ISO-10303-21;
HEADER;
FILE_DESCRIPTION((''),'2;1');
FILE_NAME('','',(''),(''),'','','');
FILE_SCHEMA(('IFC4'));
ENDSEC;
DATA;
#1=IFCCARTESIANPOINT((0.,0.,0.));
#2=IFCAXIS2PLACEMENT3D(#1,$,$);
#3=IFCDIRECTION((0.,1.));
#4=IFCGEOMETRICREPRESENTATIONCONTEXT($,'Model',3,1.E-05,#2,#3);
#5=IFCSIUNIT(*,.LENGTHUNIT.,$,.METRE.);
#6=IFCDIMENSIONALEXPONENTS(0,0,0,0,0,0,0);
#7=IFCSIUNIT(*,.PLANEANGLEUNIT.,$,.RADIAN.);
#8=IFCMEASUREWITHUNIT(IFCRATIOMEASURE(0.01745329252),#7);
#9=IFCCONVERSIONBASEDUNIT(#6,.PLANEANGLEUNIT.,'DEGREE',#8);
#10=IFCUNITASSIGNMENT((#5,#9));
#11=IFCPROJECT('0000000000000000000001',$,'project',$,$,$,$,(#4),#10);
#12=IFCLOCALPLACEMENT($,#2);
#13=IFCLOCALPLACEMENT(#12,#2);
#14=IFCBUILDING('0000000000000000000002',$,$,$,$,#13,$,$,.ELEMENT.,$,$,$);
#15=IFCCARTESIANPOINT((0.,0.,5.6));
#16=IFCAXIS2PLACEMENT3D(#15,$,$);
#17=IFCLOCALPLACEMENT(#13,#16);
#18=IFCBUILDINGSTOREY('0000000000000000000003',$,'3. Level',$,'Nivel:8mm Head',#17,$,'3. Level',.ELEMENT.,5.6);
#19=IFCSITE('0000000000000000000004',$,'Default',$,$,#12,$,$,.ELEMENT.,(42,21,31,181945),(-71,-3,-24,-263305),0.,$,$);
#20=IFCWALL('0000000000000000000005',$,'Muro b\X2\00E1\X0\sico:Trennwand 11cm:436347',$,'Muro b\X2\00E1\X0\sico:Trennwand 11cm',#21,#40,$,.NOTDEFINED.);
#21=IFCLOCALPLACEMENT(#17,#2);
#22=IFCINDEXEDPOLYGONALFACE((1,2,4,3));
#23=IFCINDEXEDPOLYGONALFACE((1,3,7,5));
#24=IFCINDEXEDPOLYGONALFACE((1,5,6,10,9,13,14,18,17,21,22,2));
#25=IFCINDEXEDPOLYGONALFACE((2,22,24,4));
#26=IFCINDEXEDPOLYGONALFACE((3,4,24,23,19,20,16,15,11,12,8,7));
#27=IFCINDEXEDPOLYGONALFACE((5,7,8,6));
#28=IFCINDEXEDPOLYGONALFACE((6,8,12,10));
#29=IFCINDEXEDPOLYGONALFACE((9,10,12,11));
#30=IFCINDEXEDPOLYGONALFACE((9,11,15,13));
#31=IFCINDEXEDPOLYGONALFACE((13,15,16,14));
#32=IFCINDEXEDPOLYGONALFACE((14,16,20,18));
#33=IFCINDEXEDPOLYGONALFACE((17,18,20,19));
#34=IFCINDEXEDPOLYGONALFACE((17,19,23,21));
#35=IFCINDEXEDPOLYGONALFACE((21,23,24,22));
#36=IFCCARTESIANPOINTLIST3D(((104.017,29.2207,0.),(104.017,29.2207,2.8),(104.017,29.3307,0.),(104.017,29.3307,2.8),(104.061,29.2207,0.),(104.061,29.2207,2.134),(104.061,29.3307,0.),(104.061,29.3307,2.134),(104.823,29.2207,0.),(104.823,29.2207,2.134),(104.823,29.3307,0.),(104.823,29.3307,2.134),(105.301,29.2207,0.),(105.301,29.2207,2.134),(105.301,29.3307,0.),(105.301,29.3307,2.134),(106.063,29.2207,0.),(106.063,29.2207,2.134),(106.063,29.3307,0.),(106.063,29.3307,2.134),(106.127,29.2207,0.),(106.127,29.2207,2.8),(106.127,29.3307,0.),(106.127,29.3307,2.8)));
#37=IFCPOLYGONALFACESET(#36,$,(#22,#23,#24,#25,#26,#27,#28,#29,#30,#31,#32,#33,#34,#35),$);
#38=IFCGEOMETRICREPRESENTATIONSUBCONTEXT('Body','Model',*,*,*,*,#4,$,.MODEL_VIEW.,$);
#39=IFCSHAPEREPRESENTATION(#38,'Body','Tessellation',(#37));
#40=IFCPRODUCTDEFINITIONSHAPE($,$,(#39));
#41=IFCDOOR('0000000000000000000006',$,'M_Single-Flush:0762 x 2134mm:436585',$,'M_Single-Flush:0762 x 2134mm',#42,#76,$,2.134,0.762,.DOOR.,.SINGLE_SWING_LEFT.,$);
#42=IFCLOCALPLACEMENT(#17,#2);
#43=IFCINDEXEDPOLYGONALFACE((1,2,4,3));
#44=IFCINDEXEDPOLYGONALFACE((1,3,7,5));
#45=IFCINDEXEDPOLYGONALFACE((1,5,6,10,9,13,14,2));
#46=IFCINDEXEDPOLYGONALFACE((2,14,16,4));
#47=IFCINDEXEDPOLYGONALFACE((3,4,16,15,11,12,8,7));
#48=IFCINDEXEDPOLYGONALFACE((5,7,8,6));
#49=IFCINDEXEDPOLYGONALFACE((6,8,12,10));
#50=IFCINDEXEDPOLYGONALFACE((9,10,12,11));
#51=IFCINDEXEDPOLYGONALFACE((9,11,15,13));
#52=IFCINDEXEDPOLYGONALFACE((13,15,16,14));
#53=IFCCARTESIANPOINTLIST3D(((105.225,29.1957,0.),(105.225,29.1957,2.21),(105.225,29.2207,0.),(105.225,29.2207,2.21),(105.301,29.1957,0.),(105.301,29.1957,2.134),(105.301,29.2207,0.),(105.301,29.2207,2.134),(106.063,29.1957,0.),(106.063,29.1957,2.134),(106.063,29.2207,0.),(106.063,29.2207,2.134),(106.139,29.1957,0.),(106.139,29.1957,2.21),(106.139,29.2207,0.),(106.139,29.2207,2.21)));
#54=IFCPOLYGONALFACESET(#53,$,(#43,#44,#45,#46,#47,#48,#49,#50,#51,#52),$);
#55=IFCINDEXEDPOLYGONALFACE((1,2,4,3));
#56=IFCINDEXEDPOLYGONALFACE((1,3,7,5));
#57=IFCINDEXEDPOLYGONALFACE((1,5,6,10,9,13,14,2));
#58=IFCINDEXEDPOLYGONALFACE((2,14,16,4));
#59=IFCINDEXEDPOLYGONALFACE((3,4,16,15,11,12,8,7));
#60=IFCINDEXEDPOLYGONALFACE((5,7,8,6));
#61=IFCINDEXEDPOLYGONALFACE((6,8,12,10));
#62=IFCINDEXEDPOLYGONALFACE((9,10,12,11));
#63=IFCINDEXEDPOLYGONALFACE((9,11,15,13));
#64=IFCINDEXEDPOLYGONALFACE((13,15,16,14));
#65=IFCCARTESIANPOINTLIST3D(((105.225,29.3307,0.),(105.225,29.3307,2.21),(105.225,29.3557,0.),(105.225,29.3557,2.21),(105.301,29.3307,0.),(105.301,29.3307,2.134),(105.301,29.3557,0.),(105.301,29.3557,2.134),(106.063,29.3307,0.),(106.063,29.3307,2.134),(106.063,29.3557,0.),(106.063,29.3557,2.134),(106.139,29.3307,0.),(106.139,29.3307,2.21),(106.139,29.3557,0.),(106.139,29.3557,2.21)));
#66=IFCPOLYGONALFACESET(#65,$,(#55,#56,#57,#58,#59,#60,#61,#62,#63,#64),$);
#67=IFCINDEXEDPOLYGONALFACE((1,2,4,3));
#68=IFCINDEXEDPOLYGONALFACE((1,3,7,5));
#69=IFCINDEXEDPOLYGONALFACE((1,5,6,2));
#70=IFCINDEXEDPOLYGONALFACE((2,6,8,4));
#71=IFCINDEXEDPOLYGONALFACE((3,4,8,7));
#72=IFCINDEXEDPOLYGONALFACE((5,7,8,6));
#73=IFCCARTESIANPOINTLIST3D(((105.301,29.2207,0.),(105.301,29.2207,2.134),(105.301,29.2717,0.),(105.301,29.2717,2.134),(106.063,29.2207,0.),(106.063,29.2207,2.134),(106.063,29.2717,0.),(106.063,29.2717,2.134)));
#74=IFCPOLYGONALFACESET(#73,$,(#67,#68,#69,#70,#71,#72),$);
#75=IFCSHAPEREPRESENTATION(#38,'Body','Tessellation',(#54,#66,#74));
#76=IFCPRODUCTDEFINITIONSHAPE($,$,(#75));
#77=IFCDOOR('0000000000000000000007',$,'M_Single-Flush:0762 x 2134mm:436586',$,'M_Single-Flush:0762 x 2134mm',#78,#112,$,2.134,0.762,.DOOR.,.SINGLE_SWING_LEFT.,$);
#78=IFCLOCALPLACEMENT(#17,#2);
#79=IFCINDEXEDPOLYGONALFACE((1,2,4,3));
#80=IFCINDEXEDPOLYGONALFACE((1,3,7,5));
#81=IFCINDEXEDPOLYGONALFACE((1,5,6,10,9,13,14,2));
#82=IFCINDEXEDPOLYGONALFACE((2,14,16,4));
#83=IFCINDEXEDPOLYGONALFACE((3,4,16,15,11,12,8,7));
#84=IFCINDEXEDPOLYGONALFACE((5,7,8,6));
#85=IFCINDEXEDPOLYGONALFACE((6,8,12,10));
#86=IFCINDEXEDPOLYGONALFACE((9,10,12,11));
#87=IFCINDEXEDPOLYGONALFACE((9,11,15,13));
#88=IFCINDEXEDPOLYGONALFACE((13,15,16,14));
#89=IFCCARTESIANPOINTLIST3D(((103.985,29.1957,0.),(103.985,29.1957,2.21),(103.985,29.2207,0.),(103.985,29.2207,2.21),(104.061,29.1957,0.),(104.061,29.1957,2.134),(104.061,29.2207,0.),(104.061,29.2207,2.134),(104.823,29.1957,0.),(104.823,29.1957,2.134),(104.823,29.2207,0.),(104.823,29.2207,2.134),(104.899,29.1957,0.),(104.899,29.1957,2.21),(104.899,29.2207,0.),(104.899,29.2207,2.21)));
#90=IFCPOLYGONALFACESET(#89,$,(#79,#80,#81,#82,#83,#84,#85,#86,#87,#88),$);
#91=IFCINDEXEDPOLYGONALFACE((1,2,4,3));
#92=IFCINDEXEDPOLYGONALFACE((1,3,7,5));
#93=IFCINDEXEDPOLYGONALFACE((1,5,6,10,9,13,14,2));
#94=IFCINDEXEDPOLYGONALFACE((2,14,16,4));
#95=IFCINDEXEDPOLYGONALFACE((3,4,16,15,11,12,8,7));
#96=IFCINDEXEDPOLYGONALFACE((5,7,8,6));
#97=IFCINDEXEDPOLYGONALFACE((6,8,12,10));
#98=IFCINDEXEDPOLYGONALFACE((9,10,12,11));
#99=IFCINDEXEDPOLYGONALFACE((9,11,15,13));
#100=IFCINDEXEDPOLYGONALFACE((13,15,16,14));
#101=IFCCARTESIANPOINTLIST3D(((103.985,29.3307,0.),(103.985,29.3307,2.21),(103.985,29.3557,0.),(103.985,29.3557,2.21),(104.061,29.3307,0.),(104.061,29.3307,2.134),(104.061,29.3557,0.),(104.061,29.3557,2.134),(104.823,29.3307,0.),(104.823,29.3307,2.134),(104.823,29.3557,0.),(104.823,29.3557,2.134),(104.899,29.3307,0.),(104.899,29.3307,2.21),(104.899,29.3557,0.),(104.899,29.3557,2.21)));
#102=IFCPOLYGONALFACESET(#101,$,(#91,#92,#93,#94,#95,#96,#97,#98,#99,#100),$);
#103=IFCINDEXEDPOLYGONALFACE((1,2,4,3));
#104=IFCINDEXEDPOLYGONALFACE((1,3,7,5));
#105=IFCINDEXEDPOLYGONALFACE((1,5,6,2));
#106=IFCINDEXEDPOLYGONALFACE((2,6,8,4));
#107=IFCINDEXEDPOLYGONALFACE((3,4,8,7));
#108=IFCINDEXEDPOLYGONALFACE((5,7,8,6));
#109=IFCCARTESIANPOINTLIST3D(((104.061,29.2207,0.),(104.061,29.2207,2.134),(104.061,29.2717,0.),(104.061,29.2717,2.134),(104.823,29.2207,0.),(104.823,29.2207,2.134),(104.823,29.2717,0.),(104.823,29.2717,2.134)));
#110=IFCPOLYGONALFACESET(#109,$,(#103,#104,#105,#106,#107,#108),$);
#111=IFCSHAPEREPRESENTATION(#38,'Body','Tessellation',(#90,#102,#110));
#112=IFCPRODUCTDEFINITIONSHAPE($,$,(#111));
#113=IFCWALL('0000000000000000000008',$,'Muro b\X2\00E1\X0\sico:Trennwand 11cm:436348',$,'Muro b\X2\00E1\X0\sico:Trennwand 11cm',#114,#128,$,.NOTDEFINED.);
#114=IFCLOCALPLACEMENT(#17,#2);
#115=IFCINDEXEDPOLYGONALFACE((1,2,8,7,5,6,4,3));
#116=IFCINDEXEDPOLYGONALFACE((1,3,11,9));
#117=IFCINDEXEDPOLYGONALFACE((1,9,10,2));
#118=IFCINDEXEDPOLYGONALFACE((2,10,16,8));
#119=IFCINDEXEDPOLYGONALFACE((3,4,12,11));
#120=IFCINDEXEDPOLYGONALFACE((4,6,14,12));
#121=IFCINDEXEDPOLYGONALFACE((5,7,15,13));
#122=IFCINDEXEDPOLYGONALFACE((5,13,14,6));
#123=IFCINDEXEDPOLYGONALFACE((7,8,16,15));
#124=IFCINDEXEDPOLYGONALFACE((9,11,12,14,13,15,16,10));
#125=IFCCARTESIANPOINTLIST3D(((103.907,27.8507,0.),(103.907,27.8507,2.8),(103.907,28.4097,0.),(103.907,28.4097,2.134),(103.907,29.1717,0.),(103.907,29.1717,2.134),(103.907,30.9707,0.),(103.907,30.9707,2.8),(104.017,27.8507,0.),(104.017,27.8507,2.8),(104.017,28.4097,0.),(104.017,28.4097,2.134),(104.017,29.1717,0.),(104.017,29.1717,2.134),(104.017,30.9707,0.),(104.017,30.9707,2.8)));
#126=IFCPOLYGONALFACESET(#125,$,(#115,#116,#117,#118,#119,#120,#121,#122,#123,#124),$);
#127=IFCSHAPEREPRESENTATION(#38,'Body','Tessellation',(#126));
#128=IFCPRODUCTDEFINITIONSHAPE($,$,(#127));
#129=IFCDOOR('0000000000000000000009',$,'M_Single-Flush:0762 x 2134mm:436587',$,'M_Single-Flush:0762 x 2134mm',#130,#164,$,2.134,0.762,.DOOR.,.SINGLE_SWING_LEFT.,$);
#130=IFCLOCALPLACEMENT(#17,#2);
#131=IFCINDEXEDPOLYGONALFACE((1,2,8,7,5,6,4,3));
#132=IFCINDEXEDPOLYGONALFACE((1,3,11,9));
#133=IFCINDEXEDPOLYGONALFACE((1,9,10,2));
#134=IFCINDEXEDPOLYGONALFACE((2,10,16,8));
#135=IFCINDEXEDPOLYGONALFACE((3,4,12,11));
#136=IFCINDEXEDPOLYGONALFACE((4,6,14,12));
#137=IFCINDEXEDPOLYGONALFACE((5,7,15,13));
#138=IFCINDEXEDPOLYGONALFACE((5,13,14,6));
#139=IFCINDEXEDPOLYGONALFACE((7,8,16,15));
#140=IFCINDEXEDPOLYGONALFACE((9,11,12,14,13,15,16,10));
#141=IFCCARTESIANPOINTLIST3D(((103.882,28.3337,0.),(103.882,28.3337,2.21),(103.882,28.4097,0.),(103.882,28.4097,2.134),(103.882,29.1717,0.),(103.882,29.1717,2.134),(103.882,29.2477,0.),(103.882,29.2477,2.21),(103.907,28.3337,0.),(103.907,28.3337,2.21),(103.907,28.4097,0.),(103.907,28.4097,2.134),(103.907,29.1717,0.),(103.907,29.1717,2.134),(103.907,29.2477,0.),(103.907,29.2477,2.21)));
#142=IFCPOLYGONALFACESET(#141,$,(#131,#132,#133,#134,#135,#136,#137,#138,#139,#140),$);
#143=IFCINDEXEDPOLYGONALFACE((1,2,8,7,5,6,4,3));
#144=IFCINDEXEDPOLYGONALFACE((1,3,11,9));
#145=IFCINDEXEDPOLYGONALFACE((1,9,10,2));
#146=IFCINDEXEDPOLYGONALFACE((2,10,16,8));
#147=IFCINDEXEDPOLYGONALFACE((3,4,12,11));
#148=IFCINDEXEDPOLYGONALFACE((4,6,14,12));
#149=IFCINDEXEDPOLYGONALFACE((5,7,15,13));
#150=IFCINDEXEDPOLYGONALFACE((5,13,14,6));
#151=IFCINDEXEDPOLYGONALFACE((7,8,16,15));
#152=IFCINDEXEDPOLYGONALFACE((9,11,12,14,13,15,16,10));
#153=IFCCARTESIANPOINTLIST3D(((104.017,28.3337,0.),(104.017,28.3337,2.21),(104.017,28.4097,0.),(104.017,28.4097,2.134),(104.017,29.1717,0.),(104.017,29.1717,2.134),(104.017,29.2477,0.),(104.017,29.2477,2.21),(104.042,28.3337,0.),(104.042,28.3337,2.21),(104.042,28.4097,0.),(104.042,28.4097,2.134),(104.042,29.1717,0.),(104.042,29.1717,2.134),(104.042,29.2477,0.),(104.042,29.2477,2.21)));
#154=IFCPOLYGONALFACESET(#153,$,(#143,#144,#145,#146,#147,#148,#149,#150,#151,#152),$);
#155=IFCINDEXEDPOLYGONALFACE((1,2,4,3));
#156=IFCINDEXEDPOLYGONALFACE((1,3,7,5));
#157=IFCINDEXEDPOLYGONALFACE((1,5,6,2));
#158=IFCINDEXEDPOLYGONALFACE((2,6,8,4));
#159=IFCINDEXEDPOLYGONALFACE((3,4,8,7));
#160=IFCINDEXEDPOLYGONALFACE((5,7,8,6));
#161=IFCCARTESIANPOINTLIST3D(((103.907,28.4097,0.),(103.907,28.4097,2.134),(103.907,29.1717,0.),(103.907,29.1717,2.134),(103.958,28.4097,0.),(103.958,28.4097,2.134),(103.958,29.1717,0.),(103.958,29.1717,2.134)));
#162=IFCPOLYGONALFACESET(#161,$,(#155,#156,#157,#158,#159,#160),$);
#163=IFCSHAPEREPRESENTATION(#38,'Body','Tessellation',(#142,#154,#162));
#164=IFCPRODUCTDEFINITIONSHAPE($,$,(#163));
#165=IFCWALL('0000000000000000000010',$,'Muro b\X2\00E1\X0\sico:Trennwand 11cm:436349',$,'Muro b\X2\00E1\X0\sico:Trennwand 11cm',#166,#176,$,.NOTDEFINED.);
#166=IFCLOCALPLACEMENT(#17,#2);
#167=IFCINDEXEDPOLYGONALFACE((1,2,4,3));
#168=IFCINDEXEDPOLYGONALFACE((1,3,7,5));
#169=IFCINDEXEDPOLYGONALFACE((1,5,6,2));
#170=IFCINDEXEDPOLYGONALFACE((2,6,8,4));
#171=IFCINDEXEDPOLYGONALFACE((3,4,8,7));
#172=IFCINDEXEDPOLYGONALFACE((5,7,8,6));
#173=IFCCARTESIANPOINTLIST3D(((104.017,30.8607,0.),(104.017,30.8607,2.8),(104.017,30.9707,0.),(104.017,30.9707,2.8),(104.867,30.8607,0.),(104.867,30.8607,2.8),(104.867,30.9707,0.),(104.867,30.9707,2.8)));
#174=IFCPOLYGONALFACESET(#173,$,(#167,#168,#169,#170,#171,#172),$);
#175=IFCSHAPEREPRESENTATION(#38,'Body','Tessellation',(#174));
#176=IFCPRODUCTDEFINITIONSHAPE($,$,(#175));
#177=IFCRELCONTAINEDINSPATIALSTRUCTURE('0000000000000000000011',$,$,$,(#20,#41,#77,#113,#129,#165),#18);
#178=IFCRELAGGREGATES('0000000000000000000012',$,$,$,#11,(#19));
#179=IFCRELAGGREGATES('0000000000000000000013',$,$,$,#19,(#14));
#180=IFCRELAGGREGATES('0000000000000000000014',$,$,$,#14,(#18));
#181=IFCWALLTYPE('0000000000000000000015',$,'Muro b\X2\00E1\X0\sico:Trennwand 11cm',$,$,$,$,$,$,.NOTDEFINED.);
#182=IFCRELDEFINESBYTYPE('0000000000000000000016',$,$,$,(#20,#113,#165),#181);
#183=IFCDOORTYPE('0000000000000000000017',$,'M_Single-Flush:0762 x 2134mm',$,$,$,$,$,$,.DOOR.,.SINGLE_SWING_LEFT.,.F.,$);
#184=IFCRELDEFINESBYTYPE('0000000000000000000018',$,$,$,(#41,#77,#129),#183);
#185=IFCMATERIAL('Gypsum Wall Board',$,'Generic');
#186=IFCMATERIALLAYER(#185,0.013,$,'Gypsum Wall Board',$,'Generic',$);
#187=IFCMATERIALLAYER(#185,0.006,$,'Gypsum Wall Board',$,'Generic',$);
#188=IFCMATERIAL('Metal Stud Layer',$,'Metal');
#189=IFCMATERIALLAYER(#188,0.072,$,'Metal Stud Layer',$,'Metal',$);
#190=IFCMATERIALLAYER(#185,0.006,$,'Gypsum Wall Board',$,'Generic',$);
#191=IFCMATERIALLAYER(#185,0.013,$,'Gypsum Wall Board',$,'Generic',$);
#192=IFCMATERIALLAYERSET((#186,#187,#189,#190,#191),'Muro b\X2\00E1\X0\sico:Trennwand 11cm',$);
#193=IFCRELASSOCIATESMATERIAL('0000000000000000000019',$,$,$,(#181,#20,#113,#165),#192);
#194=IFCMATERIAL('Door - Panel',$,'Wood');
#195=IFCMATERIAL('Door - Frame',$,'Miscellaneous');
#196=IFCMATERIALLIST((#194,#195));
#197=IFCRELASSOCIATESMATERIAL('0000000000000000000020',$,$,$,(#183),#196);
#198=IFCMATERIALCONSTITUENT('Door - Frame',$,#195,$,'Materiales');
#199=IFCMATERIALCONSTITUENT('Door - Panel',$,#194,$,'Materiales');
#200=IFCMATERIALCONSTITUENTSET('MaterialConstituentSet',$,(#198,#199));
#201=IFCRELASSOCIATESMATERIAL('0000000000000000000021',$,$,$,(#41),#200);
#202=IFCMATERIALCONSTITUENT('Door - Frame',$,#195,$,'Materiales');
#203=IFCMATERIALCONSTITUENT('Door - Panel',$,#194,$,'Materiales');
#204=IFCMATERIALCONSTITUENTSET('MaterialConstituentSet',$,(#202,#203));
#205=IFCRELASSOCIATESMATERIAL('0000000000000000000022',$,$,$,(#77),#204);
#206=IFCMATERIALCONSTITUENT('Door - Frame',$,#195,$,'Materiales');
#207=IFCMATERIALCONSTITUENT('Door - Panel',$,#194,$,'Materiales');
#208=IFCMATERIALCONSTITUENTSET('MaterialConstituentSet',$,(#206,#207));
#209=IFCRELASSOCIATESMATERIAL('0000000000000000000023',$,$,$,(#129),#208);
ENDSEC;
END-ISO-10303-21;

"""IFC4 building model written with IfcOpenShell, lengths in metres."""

from ifc_helpers import new_model, entity, si_unit, converted_unit, direction, frame, frame_2d, origin, origin_2d_with_axis, place, context, subcontext, project, spatial, polyline, rectangle, outline, extrude, source, transform, mapped, material, material_list, layer, layer_set, layer_usage, constituent, constituent_set, type_object, type_shapes, element, fill, save


model = new_model("IFC4")

# Units and contexts
model_context = context("Model", 3, precision=1e-05, world=origin(), true_north=direction((0.0, 1.0)))
body_context = subcontext(model_context, "Body", "Model", "MODEL_VIEW")
ifc_project = project(units=[si_unit("LENGTHUNIT", "METRE"), converted_unit("PLANEANGLEUNIT", "DEGREE", entity("IfcRatioMeasure", 0.01745329252), si_unit("PLANEANGLEUNIT", "RADIAN"), dimensions=[0, 0, 0, 0, 0, 0, 0])], contexts=[model_context])

# Site, building, storey
site_placement = place(None, origin())
site = spatial("IfcSite", under=ifc_project, at=site_placement, Name="Default", CompositionType="ELEMENT", RefLatitude=(42, 21, 31, 181945), RefLongitude=(-71, -3, -24, -263305), RefElevation=0.0)
building_placement = place(site_placement, origin())
building = spatial("IfcBuilding", under=site, at=building_placement, CompositionType="ELEMENT")
storey_placement = place(building_placement, frame((0.0, 0.0, 5.6)))
storey = spatial("IfcBuildingStorey", under=building, at=storey_placement, Name="3. Level", ObjectType="Nivel:8mm Head", LongName="3. Level", CompositionType="ELEMENT", Elevation=5.6)

# Shared definitions
ifc_material_1 = material(Name="Gypsum Wall Board", Category="Generic")
ifc_layer_1 = layer(ifc_material_1, 0.013, Name="Gypsum Wall Board", Category="Generic")
ifc_layer_2 = layer(ifc_material_1, 0.006, Name="Gypsum Wall Board", Category="Generic")
ifc_material_2 = material(Name="Metal Stud Layer", Category="Metal")
ifc_layer_3 = layer(ifc_material_2, 0.072, Name="Metal Stud Layer", Category="Metal")
ifc_layer_4 = layer(ifc_material_1, 0.006, Name="Gypsum Wall Board", Category="Generic")
ifc_layer_5 = layer(ifc_material_1, 0.013, Name="Gypsum Wall Board", Category="Generic")
ifc_layer_set_1 = layer_set([ifc_layer_1, ifc_layer_2, ifc_layer_3, ifc_layer_4, ifc_layer_5], Name="Muro básico:Trennwand 11cm")
wall_type_1 = type_object("IfcWallType", Name="Muro básico:Trennwand 11cm", PredefinedType="NOTDEFINED", material=ifc_layer_set_1)
ifc_material_3 = material(Name="Door - Frame", Category="Miscellaneous")

# Shared definitions
ifc_material_4 = material(Name="Door - Panel", Category="Wood")
ifc_material_list_1 = material_list([ifc_material_4, ifc_material_3])
door_type_1 = type_object("IfcDoorType", Name="M_Single-Flush:0762 x 2134mm", OperationType="SINGLE_SWING_LEFT", ParameterTakesPrecedence=False, PredefinedType="DOOR", material=ifc_material_list_1)
shared_shape_1 = source(origin(), body_context, "Body", "SweptSolid", [
    extrude(outline(polyline([(-0.457, -1.124), (0.457, -1.124), (0.457, 1.086), (0.381, 1.086), (0.381, -1.048), (-0.381, -1.048), (-0.381, 1.086), (-0.457, 1.086), (-0.457, -1.124)])), frame((0.381, 0.135, 1.086), z_axis=(0.0, -1.0, 0.0), x_axis=(-1.0, 0.0, 0.0)), (0.0, 0.0, 1.0), 0.025),
    extrude(outline(polyline([(-1.124, -0.457), (1.086, -0.457), (1.086, -0.381), (-1.048, -0.381), (-1.048, 0.381), (1.086, 0.381), (1.086, 0.457), (-1.124, 0.457), (-1.124, -0.457)])), frame((0.381, 0.0, 1.086), z_axis=(0.0, -1.0, 0.0), x_axis=(0.0, 0.0, -1.0)), (0.0, 0.0, 1.0), 0.025),
    extrude(rectangle(XDim=0.762, YDim=0.051, at=origin_2d_with_axis()), frame((0.381, 0.0845, 0.0)), (0.0, 0.0, 1.0), 2.134),
])
type_shapes(door_type_1, [shared_shape_1])

# Wall, openings, doors
ifc_layer_usage_1 = layer_usage(ifc_layer_set_1, "AXIS2", "NEGATIVE", 0.055)
wall_1_placement = place(storey_placement, frame((106.127, 29.2757, 0.0), z_axis=(0.0, 0.0, 1.0), x_axis=(-1.0, 0.0, 0.0)))
wall_1 = element("IfcWall", 1, at=wall_1_placement, inside=storey, type_object=wall_type_1, material=ifc_layer_usage_1, Name="Muro básico:Trennwand 11cm:436347", ObjectType="Muro básico:Trennwand 11cm", PredefinedType="NOTDEFINED", context=body_context, shape_type="SweptSolid", body=[
    extrude(rectangle(XDim=2.11, YDim=0.11, at=frame_2d((1.055, 0.0), x_axis=(-1.0, 0.0))), origin(), (0.0, 0.0, 1.0), 2.8),
])
opening_1_placement = place(wall_1_placement, frame((0.064, -0.055, 0.0)))
opening_1 = element("IfcOpeningElement", 2, at=opening_1_placement, cuts=wall_1, ObjectType="Opening", PredefinedType="OPENING", context=body_context, shape_type="SweptSolid", body=[
    extrude(rectangle(XDim=0.762, YDim=2.134, at=frame_2d((1.067, 0.381), x_axis=(0.0, -1.0))), frame((0.0, 0.0, 0.0), z_axis=(0.0, 1.0, 0.0), x_axis=(0.0, 0.0, 1.0)), (0.0, 0.0, 1.0), 0.11),
])
opening_2_placement = place(wall_1_placement, frame((1.304, -0.055, 0.0)))
opening_2 = element("IfcOpeningElement", 3, at=opening_2_placement, cuts=wall_1, ObjectType="Opening", PredefinedType="OPENING", context=body_context, shape_type="SweptSolid", body=[
    extrude(rectangle(XDim=0.762, YDim=2.134, at=frame_2d((1.067, 0.381), x_axis=(0.0, -1.0))), frame((0.0, 0.0, 0.0), z_axis=(0.0, 1.0, 0.0), x_axis=(0.0, 0.0, 1.0)), (0.0, 0.0, 1.0), 0.11),
])
ifc_constituent_1 = constituent(ifc_material_3, Name="Door - Frame", Category="Materiales")
ifc_constituent_2 = constituent(ifc_material_4, Name="Door - Panel", Category="Materiales")
ifc_constituent_set_1 = constituent_set(constituents=[ifc_constituent_1, ifc_constituent_2], Name="MaterialConstituentSet")
door_1_placement = place(opening_1_placement, origin())
door_1 = element("IfcDoor", 4, at=door_1_placement, inside=storey, type_object=door_type_1, material=ifc_constituent_set_1, Name="M_Single-Flush:0762 x 2134mm:436585", ObjectType="M_Single-Flush:0762 x 2134mm", OperationType="SINGLE_SWING_LEFT", OverallHeight=2.134, OverallWidth=0.762, PredefinedType="DOOR", context=body_context, shape_type="MappedRepresentation", body=[
    mapped(shared_shape_1, transform((0.0, 0.0, 0.0), scale=1.0)),
])
fill(opening_1, door_1)
ifc_constituent_3 = constituent(ifc_material_3, Name="Door - Frame", Category="Materiales")
ifc_constituent_4 = constituent(ifc_material_4, Name="Door - Panel", Category="Materiales")
ifc_constituent_set_2 = constituent_set(constituents=[ifc_constituent_3, ifc_constituent_4], Name="MaterialConstituentSet")
door_2_placement = place(opening_2_placement, origin())
door_2 = element("IfcDoor", 5, at=door_2_placement, inside=storey, type_object=door_type_1, material=ifc_constituent_set_2, Name="M_Single-Flush:0762 x 2134mm:436586", ObjectType="M_Single-Flush:0762 x 2134mm", OperationType="SINGLE_SWING_LEFT", OverallHeight=2.134, OverallWidth=0.762, PredefinedType="DOOR", context=body_context, shape_type="MappedRepresentation", body=[
    mapped(shared_shape_1, transform((0.0, 0.0, 0.0), scale=1.0)),
])
fill(opening_2, door_2)

# Wall, opening, door
ifc_layer_usage_2 = layer_usage(ifc_layer_set_1, "AXIS2", "NEGATIVE", 0.055)
wall_2_placement = place(storey_placement, frame((103.962, 27.8507, 0.0), z_axis=(0.0, 0.0, 1.0), x_axis=(0.0, 1.0, 0.0)))
wall_2 = element("IfcWall", 6, at=wall_2_placement, inside=storey, type_object=wall_type_1, material=ifc_layer_usage_2, Name="Muro básico:Trennwand 11cm:436348", ObjectType="Muro básico:Trennwand 11cm", PredefinedType="NOTDEFINED", context=body_context, shape_type="SweptSolid", body=[
    extrude(rectangle(XDim=3.12, YDim=0.11, at=frame_2d((1.56, 0.0), x_axis=(-1.0, 0.0))), origin(), (0.0, 0.0, 1.0), 2.8),
])
opening_3_placement = place(wall_2_placement, frame((0.559, -0.055, 0.0)))
opening_3 = element("IfcOpeningElement", 7, at=opening_3_placement, cuts=wall_2, ObjectType="Opening", PredefinedType="OPENING", context=body_context, shape_type="SweptSolid", body=[
    extrude(rectangle(XDim=0.762, YDim=2.134, at=frame_2d((1.067, 0.381), x_axis=(0.0, -1.0))), frame((0.0, 0.0, 0.0), z_axis=(0.0, 1.0, 0.0), x_axis=(0.0, 0.0, 1.0)), (0.0, 0.0, 1.0), 0.11),
])
ifc_constituent_5 = constituent(ifc_material_3, Name="Door - Frame", Category="Materiales")
ifc_constituent_6 = constituent(ifc_material_4, Name="Door - Panel", Category="Materiales")
ifc_constituent_set_3 = constituent_set(constituents=[ifc_constituent_5, ifc_constituent_6], Name="MaterialConstituentSet")
door_3_placement = place(opening_3_placement, origin())
door_3 = element("IfcDoor", 8, at=door_3_placement, inside=storey, type_object=door_type_1, material=ifc_constituent_set_3, Name="M_Single-Flush:0762 x 2134mm:436587", ObjectType="M_Single-Flush:0762 x 2134mm", OperationType="SINGLE_SWING_LEFT", OverallHeight=2.134, OverallWidth=0.762, PredefinedType="DOOR", context=body_context, shape_type="MappedRepresentation", body=[
    mapped(shared_shape_1, transform((0.0, 0.0, 0.0), scale=1.0)),
])
fill(opening_3, door_3)

# Wall
ifc_layer_usage_3 = layer_usage(ifc_layer_set_1, "AXIS2", "NEGATIVE", 0.055)
wall_3_placement = place(storey_placement, frame((104.017, 30.9157, 0.0)))
element("IfcWall", 9, at=wall_3_placement, inside=storey, type_object=wall_type_1, material=ifc_layer_usage_3, Name="Muro básico:Trennwand 11cm:436349", ObjectType="Muro básico:Trennwand 11cm", PredefinedType="NOTDEFINED", context=body_context, shape_type="SweptSolid", body=[
    extrude(rectangle(XDim=0.85, YDim=0.11, at=frame_2d((0.425, 0.0), x_axis=(-1.0, 0.0))), origin(), (0.0, 0.0, 1.0), 2.8),
])

save(model, "model.ifc")
